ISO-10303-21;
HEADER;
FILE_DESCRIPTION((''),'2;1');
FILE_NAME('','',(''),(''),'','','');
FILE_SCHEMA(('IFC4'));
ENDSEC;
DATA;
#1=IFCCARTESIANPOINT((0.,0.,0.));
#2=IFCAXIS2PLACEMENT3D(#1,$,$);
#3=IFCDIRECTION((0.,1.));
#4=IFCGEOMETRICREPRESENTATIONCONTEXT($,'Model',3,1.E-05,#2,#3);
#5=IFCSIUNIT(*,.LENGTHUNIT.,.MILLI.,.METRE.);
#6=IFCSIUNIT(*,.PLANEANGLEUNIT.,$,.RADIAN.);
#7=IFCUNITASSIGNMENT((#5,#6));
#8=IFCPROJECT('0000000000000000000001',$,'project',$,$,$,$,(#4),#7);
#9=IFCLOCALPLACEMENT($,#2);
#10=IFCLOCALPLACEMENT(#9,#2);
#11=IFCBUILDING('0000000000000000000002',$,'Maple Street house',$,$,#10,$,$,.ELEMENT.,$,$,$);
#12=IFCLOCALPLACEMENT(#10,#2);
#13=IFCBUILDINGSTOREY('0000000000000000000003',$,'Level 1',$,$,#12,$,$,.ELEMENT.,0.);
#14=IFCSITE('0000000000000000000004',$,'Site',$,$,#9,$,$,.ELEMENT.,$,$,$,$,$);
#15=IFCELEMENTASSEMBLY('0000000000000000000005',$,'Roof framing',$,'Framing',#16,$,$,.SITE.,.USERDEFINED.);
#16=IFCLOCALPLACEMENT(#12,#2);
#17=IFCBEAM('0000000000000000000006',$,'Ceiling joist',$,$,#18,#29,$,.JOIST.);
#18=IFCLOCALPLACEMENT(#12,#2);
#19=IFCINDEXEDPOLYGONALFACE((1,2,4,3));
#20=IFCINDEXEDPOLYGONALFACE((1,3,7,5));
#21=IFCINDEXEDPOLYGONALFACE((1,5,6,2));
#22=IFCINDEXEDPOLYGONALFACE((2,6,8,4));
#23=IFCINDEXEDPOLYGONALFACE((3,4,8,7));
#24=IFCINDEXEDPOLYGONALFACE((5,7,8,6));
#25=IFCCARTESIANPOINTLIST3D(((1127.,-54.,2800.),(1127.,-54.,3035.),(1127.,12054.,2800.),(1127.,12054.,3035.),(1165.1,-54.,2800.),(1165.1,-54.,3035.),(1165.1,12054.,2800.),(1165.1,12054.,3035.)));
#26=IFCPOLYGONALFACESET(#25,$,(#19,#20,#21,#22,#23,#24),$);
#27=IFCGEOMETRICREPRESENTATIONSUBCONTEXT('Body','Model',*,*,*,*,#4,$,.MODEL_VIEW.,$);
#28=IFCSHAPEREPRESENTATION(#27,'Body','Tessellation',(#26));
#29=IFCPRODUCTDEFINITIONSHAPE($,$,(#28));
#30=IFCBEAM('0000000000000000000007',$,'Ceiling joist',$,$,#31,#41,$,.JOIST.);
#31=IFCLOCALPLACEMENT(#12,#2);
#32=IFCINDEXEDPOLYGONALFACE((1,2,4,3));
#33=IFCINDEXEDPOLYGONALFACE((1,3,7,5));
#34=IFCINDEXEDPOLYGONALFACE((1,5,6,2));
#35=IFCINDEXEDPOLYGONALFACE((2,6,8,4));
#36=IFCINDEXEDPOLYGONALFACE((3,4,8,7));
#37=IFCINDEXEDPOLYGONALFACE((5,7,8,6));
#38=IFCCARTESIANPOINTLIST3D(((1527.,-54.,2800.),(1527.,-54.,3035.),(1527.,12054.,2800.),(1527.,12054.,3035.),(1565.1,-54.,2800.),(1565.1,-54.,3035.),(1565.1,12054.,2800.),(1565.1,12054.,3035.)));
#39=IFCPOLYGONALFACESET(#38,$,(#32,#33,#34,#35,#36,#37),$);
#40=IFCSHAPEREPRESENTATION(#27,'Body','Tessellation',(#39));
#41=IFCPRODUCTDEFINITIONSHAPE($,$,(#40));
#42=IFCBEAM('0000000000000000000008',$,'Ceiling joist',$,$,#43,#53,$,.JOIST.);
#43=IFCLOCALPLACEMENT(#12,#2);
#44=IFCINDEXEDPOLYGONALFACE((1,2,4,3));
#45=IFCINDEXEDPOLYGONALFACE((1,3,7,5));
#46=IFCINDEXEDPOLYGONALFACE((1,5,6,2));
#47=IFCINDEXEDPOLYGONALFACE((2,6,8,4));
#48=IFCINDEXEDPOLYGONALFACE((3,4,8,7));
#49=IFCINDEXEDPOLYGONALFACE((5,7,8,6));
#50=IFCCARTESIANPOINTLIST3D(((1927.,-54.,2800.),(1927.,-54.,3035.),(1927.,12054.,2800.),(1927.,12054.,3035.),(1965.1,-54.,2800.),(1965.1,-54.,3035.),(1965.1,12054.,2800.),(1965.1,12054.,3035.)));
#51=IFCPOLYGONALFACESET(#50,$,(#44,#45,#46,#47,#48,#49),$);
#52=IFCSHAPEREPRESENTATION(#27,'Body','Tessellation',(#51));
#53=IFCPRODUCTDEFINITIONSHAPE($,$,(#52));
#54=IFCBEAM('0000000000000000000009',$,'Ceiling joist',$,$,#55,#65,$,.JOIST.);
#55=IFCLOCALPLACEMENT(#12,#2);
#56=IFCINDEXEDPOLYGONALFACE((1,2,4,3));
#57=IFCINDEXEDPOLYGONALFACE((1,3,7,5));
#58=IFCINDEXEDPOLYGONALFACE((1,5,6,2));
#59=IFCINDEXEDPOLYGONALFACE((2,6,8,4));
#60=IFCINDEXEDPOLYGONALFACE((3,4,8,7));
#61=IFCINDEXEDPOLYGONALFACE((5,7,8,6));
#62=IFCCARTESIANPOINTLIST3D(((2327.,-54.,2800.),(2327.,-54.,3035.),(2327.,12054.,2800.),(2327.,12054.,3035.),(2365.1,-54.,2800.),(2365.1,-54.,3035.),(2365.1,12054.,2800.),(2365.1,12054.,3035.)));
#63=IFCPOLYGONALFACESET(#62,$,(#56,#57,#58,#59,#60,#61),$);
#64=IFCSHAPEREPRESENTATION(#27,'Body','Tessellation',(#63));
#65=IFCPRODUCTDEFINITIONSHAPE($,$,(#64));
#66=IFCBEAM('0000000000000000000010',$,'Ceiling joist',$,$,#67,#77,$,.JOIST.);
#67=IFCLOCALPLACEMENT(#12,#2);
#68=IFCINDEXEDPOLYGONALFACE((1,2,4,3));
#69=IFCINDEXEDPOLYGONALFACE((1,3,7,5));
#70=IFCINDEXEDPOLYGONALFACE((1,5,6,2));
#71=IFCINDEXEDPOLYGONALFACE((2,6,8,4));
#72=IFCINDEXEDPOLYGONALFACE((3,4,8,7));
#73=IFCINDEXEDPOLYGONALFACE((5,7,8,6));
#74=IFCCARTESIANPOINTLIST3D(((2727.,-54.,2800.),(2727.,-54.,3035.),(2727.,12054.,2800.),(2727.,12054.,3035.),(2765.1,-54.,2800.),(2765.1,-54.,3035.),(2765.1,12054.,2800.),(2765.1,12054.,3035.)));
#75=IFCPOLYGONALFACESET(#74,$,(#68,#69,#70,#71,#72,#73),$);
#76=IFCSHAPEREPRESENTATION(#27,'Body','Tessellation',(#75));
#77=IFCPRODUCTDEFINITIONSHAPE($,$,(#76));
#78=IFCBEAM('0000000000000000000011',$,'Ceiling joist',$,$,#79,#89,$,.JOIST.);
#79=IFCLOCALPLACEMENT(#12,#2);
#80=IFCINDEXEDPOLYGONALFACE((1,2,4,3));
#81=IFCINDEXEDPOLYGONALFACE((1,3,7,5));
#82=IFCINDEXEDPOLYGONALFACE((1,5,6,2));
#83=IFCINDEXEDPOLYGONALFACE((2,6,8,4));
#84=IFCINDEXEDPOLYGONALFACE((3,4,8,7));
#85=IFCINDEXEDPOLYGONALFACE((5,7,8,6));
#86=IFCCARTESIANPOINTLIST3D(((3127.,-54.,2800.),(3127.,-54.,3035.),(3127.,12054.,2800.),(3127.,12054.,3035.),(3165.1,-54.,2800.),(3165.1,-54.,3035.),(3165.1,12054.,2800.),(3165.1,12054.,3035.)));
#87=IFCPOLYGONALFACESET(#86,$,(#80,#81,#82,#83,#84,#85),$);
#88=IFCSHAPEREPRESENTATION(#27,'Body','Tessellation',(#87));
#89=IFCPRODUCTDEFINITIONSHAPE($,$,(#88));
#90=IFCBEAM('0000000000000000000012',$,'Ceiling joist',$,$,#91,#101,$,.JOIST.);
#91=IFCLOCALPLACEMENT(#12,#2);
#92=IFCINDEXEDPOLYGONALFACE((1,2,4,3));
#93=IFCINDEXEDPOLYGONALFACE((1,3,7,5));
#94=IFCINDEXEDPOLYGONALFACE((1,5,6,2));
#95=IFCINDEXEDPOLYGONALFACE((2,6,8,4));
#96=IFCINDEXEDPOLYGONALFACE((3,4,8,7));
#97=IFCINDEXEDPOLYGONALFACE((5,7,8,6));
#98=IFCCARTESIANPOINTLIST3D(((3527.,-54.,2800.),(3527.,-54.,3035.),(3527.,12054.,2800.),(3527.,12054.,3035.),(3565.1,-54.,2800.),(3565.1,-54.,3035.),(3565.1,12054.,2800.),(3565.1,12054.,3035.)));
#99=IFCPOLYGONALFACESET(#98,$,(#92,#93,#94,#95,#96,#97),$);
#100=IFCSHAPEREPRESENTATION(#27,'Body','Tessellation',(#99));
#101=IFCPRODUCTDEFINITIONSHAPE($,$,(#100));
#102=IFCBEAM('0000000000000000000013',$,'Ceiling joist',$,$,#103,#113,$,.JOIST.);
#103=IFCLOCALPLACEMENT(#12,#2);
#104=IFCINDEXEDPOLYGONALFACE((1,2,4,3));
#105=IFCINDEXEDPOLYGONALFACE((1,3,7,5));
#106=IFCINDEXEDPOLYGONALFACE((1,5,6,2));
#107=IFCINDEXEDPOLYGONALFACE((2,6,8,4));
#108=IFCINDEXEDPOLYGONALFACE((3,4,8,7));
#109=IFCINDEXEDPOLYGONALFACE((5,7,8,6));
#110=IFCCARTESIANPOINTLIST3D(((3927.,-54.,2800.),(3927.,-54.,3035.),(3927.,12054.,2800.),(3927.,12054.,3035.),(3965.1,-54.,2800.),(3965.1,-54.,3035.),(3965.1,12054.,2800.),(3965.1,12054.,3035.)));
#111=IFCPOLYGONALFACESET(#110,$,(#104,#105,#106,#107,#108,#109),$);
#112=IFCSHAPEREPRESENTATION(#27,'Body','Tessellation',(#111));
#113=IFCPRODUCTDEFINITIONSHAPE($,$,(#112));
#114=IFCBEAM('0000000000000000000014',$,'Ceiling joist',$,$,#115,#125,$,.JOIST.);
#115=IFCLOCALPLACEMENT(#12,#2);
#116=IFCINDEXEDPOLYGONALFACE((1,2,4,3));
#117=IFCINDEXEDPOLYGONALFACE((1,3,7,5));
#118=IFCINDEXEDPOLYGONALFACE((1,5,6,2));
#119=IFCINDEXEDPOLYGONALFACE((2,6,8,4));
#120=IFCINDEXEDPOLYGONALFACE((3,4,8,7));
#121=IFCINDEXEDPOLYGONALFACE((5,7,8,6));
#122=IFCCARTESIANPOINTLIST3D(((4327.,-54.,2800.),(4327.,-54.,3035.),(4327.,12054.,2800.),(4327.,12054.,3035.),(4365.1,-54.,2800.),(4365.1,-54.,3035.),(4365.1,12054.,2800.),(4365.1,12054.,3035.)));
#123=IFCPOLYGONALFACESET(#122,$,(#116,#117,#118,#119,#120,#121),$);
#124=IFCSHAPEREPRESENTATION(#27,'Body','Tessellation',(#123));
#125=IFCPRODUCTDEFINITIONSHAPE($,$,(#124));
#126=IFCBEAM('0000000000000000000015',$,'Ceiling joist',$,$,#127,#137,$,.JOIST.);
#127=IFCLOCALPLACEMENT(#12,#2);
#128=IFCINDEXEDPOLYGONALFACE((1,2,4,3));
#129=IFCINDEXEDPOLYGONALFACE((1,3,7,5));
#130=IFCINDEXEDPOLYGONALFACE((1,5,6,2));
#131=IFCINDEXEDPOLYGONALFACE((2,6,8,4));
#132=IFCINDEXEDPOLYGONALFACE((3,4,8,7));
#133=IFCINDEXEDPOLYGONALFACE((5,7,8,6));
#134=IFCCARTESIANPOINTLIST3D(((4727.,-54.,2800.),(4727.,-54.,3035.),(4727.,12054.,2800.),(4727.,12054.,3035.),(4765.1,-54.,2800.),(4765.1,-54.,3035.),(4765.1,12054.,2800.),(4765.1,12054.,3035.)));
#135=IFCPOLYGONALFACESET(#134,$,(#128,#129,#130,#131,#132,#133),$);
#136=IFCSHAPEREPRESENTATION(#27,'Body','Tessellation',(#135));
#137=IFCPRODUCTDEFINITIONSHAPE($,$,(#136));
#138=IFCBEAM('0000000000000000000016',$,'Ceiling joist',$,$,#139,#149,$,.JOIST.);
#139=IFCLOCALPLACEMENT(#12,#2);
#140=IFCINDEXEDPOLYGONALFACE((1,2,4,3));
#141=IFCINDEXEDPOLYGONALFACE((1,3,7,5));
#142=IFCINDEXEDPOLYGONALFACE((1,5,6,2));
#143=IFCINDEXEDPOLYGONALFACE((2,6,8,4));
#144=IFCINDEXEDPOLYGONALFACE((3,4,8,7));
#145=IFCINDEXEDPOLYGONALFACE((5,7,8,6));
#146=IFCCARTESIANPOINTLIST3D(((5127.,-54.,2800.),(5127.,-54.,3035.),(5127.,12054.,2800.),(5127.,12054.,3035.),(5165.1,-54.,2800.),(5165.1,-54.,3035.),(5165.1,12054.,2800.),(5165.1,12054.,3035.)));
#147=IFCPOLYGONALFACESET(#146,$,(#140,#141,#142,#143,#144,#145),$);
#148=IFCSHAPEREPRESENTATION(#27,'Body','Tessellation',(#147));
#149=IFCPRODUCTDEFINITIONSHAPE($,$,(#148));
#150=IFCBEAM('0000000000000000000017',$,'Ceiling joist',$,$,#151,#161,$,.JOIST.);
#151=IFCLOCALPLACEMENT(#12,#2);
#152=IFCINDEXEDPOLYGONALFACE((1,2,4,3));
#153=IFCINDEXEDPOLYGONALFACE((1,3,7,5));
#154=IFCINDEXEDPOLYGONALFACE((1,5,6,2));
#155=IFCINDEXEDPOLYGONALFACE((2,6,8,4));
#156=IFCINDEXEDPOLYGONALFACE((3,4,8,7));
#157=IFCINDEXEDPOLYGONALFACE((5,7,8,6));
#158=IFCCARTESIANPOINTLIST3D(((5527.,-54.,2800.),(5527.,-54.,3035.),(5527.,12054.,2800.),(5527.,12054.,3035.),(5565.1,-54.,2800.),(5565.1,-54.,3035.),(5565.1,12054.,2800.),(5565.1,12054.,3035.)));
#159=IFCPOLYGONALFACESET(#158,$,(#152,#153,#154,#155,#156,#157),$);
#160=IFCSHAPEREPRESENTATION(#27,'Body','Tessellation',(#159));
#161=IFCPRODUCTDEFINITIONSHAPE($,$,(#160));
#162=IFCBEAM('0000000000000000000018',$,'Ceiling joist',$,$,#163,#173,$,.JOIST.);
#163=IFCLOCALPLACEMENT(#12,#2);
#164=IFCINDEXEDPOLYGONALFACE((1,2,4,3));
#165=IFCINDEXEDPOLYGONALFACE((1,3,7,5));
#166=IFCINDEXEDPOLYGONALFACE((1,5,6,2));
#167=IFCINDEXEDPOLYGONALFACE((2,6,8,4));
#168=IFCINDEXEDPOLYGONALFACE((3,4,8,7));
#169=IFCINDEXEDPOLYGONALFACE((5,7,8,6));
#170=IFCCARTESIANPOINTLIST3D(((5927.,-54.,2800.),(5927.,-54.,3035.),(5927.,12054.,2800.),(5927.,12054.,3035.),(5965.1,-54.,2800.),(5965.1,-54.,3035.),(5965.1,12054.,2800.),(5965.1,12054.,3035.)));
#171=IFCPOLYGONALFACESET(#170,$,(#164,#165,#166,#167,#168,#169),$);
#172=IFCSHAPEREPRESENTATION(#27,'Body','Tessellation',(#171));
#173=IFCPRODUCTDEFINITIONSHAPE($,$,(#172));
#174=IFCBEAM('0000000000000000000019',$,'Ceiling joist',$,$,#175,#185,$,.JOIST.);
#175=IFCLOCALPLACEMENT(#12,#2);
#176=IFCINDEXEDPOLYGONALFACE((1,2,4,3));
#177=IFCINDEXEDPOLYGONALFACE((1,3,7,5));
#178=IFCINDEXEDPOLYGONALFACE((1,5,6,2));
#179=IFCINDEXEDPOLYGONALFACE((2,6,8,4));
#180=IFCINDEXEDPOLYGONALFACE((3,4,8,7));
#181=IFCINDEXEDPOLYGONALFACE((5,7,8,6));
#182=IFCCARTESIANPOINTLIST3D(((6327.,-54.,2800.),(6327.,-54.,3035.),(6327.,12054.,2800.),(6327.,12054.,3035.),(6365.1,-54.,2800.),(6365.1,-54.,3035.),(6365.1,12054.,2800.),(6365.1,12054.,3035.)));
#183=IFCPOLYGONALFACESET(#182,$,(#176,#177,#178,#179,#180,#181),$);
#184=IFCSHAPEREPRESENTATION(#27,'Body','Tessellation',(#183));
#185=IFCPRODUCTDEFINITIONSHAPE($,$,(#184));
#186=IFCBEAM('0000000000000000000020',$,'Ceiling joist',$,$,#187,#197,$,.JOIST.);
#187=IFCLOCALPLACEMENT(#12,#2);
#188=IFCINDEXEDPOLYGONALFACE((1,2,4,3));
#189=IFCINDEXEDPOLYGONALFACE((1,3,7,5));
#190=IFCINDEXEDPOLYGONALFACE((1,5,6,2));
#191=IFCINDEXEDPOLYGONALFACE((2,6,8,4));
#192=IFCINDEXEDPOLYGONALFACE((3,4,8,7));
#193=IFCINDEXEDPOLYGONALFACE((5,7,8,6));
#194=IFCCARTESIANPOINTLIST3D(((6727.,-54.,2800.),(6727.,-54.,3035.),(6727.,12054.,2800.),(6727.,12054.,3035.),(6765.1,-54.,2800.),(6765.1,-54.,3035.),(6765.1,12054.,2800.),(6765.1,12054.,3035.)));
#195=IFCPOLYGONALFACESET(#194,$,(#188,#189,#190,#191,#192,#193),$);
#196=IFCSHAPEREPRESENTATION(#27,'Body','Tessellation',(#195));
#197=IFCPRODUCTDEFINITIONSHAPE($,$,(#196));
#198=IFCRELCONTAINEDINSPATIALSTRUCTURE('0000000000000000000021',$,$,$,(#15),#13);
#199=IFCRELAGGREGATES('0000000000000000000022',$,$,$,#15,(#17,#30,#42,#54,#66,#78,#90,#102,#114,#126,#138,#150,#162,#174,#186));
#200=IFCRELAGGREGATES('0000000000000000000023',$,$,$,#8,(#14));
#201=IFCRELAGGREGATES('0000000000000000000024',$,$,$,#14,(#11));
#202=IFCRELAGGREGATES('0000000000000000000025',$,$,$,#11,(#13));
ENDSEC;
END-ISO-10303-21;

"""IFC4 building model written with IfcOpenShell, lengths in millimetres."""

from ifc_helpers import new_model, si_unit, direction, frame, origin, origin_with_axes, place, context, subcontext, project, spatial, polyline, outline, extrude, element, aggregate, save


model = new_model("IFC4")

# Units and contexts
model_context = context("Model", 3, precision=1e-05, world=origin(), true_north=direction((0.0, 1.0)))
body_context = subcontext(model_context, "Body", "Model", "MODEL_VIEW")
ifc_project = project(units=[si_unit("LENGTHUNIT", "METRE", prefix="MILLI"), si_unit("PLANEANGLEUNIT", "RADIAN")], contexts=[model_context])

# Site, building, storey
site_placement = place(None, origin())
site = spatial("IfcSite", under=ifc_project, at=site_placement, Name="Site", CompositionType="ELEMENT")
building_placement = place(site_placement, origin())
building = spatial("IfcBuilding", under=site, at=building_placement, Name="Maple Street house", CompositionType="ELEMENT")
storey_placement = place(building_placement, origin())
storey = spatial("IfcBuildingStorey", under=building, at=storey_placement, Name="Level 1", CompositionType="ELEMENT", Elevation=0.0)

# Element assembly, beams
assembly_placement = place(storey_placement, origin_with_axes())
assembly = element("IfcElementAssembly", 1, at=assembly_placement, inside=storey, Name="Roof framing", ObjectType="Framing", AssemblyPlace="SITE", PredefinedType="USERDEFINED")
beam_1_placement = place(storey_placement, origin_with_axes())
beam_1 = element("IfcBeam", 2, at=beam_1_placement, Name="Ceiling joist", PredefinedType="JOIST", context=body_context, shape_type="SweptSolid", body=[
    extrude(outline(polyline([(0.0, 0.0), (38.1, 0.0), (38.1, 234.9), (0.0, 234.9), (0.0, 0.0)])), frame((1127.0, 12054.0, 2800.0), z_axis=(0.0, -1.0, 0.0), x_axis=(1.0, 0.0, 0.0)), (0.0, 0.0, 1.0), 12108.0),
])
beam_2_placement = place(storey_placement, origin_with_axes())
beam_2 = element("IfcBeam", 3, at=beam_2_placement, Name="Ceiling joist", PredefinedType="JOIST", context=body_context, shape_type="SweptSolid", body=[
    extrude(outline(polyline([(0.0, 0.0), (38.1, 0.0), (38.1, 234.9), (0.0, 234.9), (0.0, 0.0)])), frame((1527.0, 12054.0, 2800.0), z_axis=(0.0, -1.0, 0.0), x_axis=(1.0, 0.0, 0.0)), (0.0, 0.0, 1.0), 12108.0),
])
beam_3_placement = place(storey_placement, origin_with_axes())
beam_3 = element("IfcBeam", 4, at=beam_3_placement, Name="Ceiling joist", PredefinedType="JOIST", context=body_context, shape_type="SweptSolid", body=[
    extrude(outline(polyline([(0.0, 0.0), (38.1, 0.0), (38.1, 234.9), (0.0, 234.9), (0.0, 0.0)])), frame((1927.0, 12054.0, 2800.0), z_axis=(0.0, -1.0, 0.0), x_axis=(1.0, 0.0, 0.0)), (0.0, 0.0, 1.0), 12108.0),
])
beam_4_placement = place(storey_placement, origin_with_axes())
beam_4 = element("IfcBeam", 5, at=beam_4_placement, Name="Ceiling joist", PredefinedType="JOIST", context=body_context, shape_type="SweptSolid", body=[
    extrude(outline(polyline([(0.0, 0.0), (38.1, 0.0), (38.1, 234.9), (0.0, 234.9), (0.0, 0.0)])), frame((2327.0, 12054.0, 2800.0), z_axis=(0.0, -1.0, 0.0), x_axis=(1.0, 0.0, 0.0)), (0.0, 0.0, 1.0), 12108.0),
])
beam_5_placement = place(storey_placement, origin_with_axes())
beam_5 = element("IfcBeam", 6, at=beam_5_placement, Name="Ceiling joist", PredefinedType="JOIST", context=body_context, shape_type="SweptSolid", body=[
    extrude(outline(polyline([(0.0, 0.0), (38.1, 0.0), (38.1, 234.9), (0.0, 234.9), (0.0, 0.0)])), frame((2727.0, 12054.0, 2800.0), z_axis=(0.0, -1.0, 0.0), x_axis=(1.0, 0.0, 0.0)), (0.0, 0.0, 1.0), 12108.0),
])
beam_6_placement = place(storey_placement, origin_with_axes())
beam_6 = element("IfcBeam", 7, at=beam_6_placement, Name="Ceiling joist", PredefinedType="JOIST", context=body_context, shape_type="SweptSolid", body=[
    extrude(outline(polyline([(0.0, 0.0), (38.1, 0.0), (38.1, 234.9), (0.0, 234.9), (0.0, 0.0)])), frame((3127.0, 12054.0, 2800.0), z_axis=(0.0, -1.0, 0.0), x_axis=(1.0, 0.0, 0.0)), (0.0, 0.0, 1.0), 12108.0),
])
beam_7_placement = place(storey_placement, origin_with_axes())
beam_7 = element("IfcBeam", 8, at=beam_7_placement, Name="Ceiling joist", PredefinedType="JOIST", context=body_context, shape_type="SweptSolid", body=[
    extrude(outline(polyline([(0.0, 0.0), (38.1, 0.0), (38.1, 234.9), (0.0, 234.9), (0.0, 0.0)])), frame((3527.0, 12054.0, 2800.0), z_axis=(0.0, -1.0, 0.0), x_axis=(1.0, 0.0, 0.0)), (0.0, 0.0, 1.0), 12108.0),
])
beam_8_placement = place(storey_placement, origin_with_axes())
beam_8 = element("IfcBeam", 9, at=beam_8_placement, Name="Ceiling joist", PredefinedType="JOIST", context=body_context, shape_type="SweptSolid", body=[
    extrude(outline(polyline([(0.0, 0.0), (38.1, 0.0), (38.1, 234.9), (0.0, 234.9), (0.0, 0.0)])), frame((3927.0, 12054.0, 2800.0), z_axis=(0.0, -1.0, 0.0), x_axis=(1.0, 0.0, 0.0)), (0.0, 0.0, 1.0), 12108.0),
])
beam_9_placement = place(storey_placement, origin_with_axes())
beam_9 = element("IfcBeam", 10, at=beam_9_placement, Name="Ceiling joist", PredefinedType="JOIST", context=body_context, shape_type="SweptSolid", body=[
    extrude(outline(polyline([(0.0, 0.0), (38.1, 0.0), (38.1, 234.9), (0.0, 234.9), (0.0, 0.0)])), frame((4327.0, 12054.0, 2800.0), z_axis=(0.0, -1.0, 0.0), x_axis=(1.0, 0.0, 0.0)), (0.0, 0.0, 1.0), 12108.0),
])
beam_10_placement = place(storey_placement, origin_with_axes())
beam_10 = element("IfcBeam", 11, at=beam_10_placement, Name="Ceiling joist", PredefinedType="JOIST", context=body_context, shape_type="SweptSolid", body=[
    extrude(outline(polyline([(0.0, 0.0), (38.1, 0.0), (38.1, 234.9), (0.0, 234.9), (0.0, 0.0)])), frame((4727.0, 12054.0, 2800.0), z_axis=(0.0, -1.0, 0.0), x_axis=(1.0, 0.0, 0.0)), (0.0, 0.0, 1.0), 12108.0),
])
beam_11_placement = place(storey_placement, origin_with_axes())
beam_11 = element("IfcBeam", 12, at=beam_11_placement, Name="Ceiling joist", PredefinedType="JOIST", context=body_context, shape_type="SweptSolid", body=[
    extrude(outline(polyline([(0.0, 0.0), (38.1, 0.0), (38.1, 234.9), (0.0, 234.9), (0.0, 0.0)])), frame((5127.0, 12054.0, 2800.0), z_axis=(0.0, -1.0, 0.0), x_axis=(1.0, 0.0, 0.0)), (0.0, 0.0, 1.0), 12108.0),
])
beam_12_placement = place(storey_placement, origin_with_axes())
beam_12 = element("IfcBeam", 13, at=beam_12_placement, Name="Ceiling joist", PredefinedType="JOIST", context=body_context, shape_type="SweptSolid", body=[
    extrude(outline(polyline([(0.0, 0.0), (38.1, 0.0), (38.1, 234.9), (0.0, 234.9), (0.0, 0.0)])), frame((5527.0, 12054.0, 2800.0), z_axis=(0.0, -1.0, 0.0), x_axis=(1.0, 0.0, 0.0)), (0.0, 0.0, 1.0), 12108.0),
])
beam_13_placement = place(storey_placement, origin_with_axes())
beam_13 = element("IfcBeam", 14, at=beam_13_placement, Name="Ceiling joist", PredefinedType="JOIST", context=body_context, shape_type="SweptSolid", body=[
    extrude(outline(polyline([(0.0, 0.0), (38.1, 0.0), (38.1, 234.9), (0.0, 234.9), (0.0, 0.0)])), frame((5927.0, 12054.0, 2800.0), z_axis=(0.0, -1.0, 0.0), x_axis=(1.0, 0.0, 0.0)), (0.0, 0.0, 1.0), 12108.0),
])
beam_14_placement = place(storey_placement, origin_with_axes())
beam_14 = element("IfcBeam", 15, at=beam_14_placement, Name="Ceiling joist", PredefinedType="JOIST", context=body_context, shape_type="SweptSolid", body=[
    extrude(outline(polyline([(0.0, 0.0), (38.1, 0.0), (38.1, 234.9), (0.0, 234.9), (0.0, 0.0)])), frame((6327.0, 12054.0, 2800.0), z_axis=(0.0, -1.0, 0.0), x_axis=(1.0, 0.0, 0.0)), (0.0, 0.0, 1.0), 12108.0),
])
beam_15_placement = place(storey_placement, origin_with_axes())
beam_15 = element("IfcBeam", 16, at=beam_15_placement, Name="Ceiling joist", PredefinedType="JOIST", context=body_context, shape_type="SweptSolid", body=[
    extrude(outline(polyline([(0.0, 0.0), (38.1, 0.0), (38.1, 234.9), (0.0, 234.9), (0.0, 0.0)])), frame((6727.0, 12054.0, 2800.0), z_axis=(0.0, -1.0, 0.0), x_axis=(1.0, 0.0, 0.0)), (0.0, 0.0, 1.0), 12108.0),
])
aggregate(assembly, [beam_1, beam_2, beam_3, beam_4, beam_5, beam_6, beam_7, beam_8, beam_9, beam_10, beam_11, beam_12, beam_13, beam_14, beam_15])

save(model, "model.ifc")
